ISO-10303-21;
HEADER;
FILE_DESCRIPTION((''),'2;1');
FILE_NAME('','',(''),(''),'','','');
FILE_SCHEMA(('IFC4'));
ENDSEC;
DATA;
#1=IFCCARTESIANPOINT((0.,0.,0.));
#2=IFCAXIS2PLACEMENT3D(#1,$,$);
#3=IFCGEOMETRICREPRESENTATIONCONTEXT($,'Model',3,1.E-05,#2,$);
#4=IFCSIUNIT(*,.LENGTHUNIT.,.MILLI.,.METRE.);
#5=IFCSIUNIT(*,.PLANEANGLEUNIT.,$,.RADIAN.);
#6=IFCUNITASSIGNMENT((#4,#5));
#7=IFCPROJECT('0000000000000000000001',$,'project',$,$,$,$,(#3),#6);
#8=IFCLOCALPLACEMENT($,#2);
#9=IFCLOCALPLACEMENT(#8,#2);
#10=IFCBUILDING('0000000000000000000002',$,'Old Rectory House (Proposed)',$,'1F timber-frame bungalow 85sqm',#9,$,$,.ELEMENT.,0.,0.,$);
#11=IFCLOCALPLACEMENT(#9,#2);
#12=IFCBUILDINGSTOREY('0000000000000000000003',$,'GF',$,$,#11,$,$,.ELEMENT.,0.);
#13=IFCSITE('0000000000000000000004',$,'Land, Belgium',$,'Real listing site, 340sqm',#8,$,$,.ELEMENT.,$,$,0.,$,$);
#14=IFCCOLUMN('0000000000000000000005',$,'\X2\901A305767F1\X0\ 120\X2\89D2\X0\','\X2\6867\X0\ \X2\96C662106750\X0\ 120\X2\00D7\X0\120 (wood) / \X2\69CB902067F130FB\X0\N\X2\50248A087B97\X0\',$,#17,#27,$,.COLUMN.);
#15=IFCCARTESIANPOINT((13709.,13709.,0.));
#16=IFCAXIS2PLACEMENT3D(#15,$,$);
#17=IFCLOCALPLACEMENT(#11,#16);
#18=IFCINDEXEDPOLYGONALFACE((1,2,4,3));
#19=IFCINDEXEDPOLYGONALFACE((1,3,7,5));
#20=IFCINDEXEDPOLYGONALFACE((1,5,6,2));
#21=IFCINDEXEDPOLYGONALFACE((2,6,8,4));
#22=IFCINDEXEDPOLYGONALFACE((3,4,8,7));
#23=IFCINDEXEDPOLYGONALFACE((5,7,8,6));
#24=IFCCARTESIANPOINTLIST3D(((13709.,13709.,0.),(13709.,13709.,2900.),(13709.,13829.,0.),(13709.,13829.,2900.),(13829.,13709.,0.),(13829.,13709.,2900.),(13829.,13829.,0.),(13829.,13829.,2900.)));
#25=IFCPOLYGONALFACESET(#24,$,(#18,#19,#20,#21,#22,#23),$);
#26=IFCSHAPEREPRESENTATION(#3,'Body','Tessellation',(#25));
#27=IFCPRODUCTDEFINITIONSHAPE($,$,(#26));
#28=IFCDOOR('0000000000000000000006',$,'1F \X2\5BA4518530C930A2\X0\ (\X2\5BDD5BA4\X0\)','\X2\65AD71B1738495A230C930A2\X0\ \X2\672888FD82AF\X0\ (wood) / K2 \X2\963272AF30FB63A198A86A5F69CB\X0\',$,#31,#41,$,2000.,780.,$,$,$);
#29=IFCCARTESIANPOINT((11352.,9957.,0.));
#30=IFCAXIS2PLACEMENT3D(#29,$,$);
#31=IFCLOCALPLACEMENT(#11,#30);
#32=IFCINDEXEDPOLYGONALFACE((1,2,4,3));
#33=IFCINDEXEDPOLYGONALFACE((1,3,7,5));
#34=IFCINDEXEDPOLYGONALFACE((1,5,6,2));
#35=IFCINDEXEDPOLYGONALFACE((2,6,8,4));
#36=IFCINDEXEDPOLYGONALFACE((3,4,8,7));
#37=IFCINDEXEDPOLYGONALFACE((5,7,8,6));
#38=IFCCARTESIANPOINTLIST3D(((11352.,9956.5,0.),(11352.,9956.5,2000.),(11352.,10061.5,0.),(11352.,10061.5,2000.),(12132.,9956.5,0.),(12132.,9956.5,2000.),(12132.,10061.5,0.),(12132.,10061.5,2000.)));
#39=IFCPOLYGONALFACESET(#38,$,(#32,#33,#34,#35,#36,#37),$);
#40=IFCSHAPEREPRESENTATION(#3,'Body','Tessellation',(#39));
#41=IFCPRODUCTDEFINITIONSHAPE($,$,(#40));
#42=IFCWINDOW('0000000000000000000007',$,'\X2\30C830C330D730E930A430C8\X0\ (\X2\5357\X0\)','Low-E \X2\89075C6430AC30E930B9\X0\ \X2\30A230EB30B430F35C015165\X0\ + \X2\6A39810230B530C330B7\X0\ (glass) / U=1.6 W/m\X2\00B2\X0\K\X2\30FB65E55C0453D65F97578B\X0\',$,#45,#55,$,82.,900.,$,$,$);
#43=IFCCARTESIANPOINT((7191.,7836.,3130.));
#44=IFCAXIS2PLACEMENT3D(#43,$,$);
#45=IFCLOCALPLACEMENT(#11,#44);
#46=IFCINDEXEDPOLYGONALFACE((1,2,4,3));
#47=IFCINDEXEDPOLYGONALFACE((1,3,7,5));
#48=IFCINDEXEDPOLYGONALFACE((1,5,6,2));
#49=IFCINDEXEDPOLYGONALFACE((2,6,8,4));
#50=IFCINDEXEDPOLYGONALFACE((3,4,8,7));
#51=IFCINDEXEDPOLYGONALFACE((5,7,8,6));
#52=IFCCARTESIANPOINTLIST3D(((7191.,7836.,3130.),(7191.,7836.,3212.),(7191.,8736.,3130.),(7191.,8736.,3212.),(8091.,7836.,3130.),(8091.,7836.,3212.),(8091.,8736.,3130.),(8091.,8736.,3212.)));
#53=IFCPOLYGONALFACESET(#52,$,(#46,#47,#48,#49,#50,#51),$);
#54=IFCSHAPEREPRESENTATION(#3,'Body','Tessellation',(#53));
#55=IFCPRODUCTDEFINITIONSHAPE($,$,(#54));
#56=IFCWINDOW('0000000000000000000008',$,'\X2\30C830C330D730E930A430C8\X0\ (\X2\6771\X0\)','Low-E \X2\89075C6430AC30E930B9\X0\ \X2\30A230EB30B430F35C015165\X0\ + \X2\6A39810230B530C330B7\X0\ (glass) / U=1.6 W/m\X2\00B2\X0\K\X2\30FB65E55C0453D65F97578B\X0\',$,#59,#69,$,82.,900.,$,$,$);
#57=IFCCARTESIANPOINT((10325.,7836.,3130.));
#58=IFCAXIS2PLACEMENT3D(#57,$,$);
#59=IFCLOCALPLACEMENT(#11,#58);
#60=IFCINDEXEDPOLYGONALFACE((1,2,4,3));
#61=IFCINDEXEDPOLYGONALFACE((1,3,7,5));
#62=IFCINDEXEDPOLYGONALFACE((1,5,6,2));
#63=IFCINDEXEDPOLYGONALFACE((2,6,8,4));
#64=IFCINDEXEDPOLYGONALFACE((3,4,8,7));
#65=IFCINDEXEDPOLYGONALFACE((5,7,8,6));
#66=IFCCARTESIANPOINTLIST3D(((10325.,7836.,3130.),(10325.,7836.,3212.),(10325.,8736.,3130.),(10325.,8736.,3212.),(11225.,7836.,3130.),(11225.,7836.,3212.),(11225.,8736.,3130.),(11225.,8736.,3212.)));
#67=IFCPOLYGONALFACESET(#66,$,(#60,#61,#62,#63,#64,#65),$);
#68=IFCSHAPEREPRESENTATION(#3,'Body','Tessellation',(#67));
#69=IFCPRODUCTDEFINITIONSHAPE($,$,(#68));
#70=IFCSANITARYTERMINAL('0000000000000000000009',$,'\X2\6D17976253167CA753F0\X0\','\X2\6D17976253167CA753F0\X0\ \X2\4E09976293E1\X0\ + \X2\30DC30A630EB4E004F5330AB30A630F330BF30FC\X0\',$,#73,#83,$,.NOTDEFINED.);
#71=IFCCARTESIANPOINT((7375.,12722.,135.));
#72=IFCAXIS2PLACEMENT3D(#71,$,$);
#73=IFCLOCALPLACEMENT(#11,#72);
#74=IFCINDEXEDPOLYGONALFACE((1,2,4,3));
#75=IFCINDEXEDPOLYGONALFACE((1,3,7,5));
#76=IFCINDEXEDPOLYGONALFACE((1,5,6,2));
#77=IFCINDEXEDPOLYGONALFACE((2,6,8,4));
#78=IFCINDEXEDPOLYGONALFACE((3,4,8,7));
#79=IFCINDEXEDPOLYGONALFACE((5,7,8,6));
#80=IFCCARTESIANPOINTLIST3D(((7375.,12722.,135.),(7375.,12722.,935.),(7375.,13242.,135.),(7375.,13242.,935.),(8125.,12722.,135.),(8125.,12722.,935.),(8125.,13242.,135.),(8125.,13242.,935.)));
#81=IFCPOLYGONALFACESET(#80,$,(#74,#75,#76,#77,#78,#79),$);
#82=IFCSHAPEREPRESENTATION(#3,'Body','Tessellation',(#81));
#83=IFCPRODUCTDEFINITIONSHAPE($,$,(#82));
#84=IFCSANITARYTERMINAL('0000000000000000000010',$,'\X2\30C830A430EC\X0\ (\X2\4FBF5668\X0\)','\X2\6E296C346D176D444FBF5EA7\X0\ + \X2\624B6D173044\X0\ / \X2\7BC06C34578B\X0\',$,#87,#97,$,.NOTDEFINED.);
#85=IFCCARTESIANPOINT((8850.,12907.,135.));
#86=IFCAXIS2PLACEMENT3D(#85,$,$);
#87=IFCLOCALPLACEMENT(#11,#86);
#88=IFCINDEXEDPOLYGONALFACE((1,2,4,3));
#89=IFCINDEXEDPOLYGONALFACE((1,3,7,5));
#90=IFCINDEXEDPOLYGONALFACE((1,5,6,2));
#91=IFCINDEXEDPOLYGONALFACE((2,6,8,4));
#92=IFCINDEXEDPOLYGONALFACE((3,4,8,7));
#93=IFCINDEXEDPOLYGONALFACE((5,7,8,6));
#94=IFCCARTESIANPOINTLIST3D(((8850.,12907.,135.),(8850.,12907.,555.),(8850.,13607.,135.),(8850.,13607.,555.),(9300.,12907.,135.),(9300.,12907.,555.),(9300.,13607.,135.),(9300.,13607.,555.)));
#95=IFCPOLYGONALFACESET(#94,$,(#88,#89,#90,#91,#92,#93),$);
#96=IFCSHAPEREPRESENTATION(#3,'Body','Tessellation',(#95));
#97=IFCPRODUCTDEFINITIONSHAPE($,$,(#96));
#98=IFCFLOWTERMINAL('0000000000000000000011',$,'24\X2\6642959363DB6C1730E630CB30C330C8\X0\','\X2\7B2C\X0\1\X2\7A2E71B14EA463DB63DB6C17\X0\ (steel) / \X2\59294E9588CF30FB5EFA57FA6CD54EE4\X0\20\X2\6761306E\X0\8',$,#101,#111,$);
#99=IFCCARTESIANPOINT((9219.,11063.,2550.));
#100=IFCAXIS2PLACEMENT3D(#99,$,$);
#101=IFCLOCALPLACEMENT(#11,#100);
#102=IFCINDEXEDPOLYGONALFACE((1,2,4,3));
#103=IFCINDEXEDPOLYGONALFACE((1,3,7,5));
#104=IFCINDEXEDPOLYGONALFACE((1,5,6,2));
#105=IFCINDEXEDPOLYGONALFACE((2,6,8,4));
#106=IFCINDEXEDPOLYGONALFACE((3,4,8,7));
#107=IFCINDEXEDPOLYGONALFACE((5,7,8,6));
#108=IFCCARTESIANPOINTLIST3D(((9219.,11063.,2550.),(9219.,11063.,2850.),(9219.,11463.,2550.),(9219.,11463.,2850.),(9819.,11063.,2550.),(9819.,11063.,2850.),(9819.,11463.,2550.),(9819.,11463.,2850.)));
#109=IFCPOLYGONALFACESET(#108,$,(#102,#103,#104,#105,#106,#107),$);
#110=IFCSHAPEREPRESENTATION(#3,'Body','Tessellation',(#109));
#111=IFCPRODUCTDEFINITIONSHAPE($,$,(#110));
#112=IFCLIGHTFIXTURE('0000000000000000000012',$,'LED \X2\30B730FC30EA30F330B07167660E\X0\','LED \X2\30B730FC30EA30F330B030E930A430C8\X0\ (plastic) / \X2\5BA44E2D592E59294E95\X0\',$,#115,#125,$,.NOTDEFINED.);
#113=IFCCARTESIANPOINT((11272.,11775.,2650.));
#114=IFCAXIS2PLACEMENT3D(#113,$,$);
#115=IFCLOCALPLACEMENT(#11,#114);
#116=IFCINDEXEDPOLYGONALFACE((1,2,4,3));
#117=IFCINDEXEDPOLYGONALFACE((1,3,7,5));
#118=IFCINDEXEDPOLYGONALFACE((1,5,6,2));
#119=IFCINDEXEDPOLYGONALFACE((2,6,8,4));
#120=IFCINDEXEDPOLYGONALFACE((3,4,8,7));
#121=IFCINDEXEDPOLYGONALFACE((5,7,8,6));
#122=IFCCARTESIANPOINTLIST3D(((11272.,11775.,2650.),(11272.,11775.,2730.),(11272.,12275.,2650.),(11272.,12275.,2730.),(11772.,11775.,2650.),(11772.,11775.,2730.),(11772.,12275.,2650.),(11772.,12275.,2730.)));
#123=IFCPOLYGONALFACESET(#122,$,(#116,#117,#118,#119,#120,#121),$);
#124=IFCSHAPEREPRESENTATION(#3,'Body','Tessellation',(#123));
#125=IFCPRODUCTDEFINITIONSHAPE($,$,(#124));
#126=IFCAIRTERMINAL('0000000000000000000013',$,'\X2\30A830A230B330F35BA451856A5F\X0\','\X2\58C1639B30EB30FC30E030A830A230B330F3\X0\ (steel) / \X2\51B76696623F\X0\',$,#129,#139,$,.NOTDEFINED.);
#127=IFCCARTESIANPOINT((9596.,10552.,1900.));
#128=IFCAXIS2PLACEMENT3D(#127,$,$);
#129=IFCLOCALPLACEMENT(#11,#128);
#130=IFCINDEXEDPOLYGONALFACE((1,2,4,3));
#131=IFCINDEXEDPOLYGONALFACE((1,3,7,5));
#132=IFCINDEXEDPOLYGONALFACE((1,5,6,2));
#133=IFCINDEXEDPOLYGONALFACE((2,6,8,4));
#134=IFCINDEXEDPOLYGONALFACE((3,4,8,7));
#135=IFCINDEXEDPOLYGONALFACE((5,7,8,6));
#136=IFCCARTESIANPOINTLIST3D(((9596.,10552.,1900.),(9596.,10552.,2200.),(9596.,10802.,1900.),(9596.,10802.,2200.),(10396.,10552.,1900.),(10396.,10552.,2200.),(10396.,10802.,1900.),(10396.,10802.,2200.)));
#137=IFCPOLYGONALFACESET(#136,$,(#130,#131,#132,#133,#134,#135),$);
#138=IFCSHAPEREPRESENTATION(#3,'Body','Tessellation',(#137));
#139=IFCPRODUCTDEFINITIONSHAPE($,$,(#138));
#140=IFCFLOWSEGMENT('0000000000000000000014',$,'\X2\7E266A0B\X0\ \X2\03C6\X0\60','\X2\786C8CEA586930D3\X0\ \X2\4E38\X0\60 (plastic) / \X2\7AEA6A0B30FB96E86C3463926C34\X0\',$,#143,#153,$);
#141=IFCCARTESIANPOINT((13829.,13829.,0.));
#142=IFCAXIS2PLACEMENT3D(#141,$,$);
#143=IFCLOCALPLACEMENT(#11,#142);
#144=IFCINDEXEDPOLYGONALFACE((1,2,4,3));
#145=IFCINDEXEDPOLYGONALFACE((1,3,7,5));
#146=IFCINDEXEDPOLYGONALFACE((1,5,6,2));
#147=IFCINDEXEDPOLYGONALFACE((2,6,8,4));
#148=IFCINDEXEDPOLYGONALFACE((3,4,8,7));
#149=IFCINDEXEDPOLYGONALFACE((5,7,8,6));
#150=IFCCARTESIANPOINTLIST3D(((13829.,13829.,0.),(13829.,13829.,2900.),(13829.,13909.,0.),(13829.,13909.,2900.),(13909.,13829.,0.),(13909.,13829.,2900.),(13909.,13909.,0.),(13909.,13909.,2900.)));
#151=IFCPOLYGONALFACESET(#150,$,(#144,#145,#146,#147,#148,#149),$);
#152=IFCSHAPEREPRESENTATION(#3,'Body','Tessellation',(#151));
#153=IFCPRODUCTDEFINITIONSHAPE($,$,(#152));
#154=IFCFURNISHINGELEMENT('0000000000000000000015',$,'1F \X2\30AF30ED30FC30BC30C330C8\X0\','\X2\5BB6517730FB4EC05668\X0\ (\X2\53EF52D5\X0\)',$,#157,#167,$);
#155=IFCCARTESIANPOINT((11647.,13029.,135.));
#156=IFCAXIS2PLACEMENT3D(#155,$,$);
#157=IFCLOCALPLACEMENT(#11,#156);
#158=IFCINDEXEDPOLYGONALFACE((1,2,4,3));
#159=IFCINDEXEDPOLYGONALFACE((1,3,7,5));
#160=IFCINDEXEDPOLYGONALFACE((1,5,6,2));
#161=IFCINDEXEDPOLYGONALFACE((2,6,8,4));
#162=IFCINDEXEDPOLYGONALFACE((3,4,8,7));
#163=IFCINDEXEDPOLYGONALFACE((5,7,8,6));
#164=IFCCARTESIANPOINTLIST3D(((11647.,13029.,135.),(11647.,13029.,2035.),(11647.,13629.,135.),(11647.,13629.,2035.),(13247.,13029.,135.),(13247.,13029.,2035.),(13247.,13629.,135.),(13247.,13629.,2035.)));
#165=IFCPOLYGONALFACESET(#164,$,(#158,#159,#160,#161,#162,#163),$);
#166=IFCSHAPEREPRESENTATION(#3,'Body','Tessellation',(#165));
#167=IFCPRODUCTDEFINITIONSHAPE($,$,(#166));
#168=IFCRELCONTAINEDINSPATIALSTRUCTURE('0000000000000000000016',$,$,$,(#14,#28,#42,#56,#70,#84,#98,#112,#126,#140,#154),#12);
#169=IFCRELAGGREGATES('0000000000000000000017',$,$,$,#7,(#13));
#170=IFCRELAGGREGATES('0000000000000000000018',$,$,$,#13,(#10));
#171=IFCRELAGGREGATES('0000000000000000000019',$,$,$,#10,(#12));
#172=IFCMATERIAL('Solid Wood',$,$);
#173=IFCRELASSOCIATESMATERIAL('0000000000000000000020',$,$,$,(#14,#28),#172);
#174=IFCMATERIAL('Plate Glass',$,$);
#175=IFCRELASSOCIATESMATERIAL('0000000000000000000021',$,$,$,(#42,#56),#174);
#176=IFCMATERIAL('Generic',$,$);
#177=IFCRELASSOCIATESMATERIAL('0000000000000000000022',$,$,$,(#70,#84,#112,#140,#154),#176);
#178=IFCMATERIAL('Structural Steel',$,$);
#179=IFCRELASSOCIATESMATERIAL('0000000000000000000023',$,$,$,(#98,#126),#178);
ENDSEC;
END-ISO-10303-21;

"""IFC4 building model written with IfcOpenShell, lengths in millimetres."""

from ifc_helpers import new_model, si_unit, frame, frame_2d, origin, place, context, project, spatial, rectangle, extrude, material, element, save


model = new_model("IFC4")

# Units and contexts
model_context = context("Model", 3, precision=1e-05, world=origin())
ifc_project = project(units=[si_unit("LENGTHUNIT", "METRE", prefix="MILLI"), si_unit("PLANEANGLEUNIT", "RADIAN")], contexts=[model_context])

# Site, building, storey
site_placement = place(None, origin())
site = spatial("IfcSite", under=ifc_project, at=site_placement, Name="Land, Belgium", ObjectType="Real listing site, 340sqm", CompositionType="ELEMENT", RefElevation=0.0)
building_placement = place(site_placement, origin())
building = spatial("IfcBuilding", under=site, at=building_placement, Name="Old Rectory House (Proposed)", ObjectType="1F timber-frame bungalow 85sqm", CompositionType="ELEMENT", ElevationOfRefHeight=0.0, ElevationOfTerrain=0.0)
storey_placement = place(building_placement, origin())
storey = spatial("IfcBuildingStorey", under=building, at=storey_placement, Name="GF", CompositionType="ELEMENT", Elevation=0.0)

# Column
ifc_material_1 = material(Name="Solid Wood")
column_1_placement = place(storey_placement, frame((13709.0, 13709.0, 0.0)))
element("IfcColumn", 1, at=column_1_placement, inside=storey, material=ifc_material_1, Name="通し柱 120角", Description="桧 集成材 120×120 (wood) / 構造柱・N値計算", PredefinedType="COLUMN", context=model_context, shape_type="SweptSolid", body=[
    extrude(rectangle(XDim=120.0, YDim=120.0, at=frame_2d((60.0, 60.0))), frame((13709.0, 13709.0, 0.0)), (0.0, 0.0, 1.0), 2900.0),
])

# Door
door_placement = place(storey_placement, frame((11352.0, 9957.0, 0.0)))
element("IfcDoor", 2, at=door_placement, inside=storey, material=ifc_material_1, Name="1F 室内ドア (寝室)", Description="断熱玄関ドア 木製芯 (wood) / K2 防犯・採風機構", OverallHeight=2000.0, OverallWidth=780.0, context=model_context, shape_type="SweptSolid", body=[
    extrude(rectangle(XDim=780.0, YDim=105.0, at=frame_2d((390.0, 52.0))), frame((11352.0, 9957.0, 0.0)), (0.0, 0.0, 1.0), 2000.0),
])

# Windows
ifc_material_2 = material(Name="Plate Glass")
window_1_placement = place(storey_placement, frame((7191.0, 7836.0, 3130.0)))
element("IfcWindow", 3, at=window_1_placement, inside=storey, material=ifc_material_2, Name="トップライト (南)", Description="Low-E 複層ガラス アルゴン封入 + 樹脂サッシ (glass) / U=1.6 W/m²K・日射取得型", OverallHeight=82.0, OverallWidth=900.0, context=model_context, shape_type="SweptSolid", body=[
    extrude(rectangle(XDim=900.0, YDim=900.0, at=frame_2d((450.0, 450.0))), frame((7191.0, 7836.0, 3130.0)), (0.0, 0.0, 1.0), 82.0),
])
window_2_placement = place(storey_placement, frame((10325.0, 7836.0, 3130.0)))
element("IfcWindow", 4, at=window_2_placement, inside=storey, material=ifc_material_2, Name="トップライト (東)", Description="Low-E 複層ガラス アルゴン封入 + 樹脂サッシ (glass) / U=1.6 W/m²K・日射取得型", OverallHeight=82.0, OverallWidth=900.0, context=model_context, shape_type="SweptSolid", body=[
    extrude(rectangle(XDim=900.0, YDim=900.0, at=frame_2d((450.0, 450.0))), frame((10325.0, 7836.0, 3130.0)), (0.0, 0.0, 1.0), 82.0),
])

# Sanitary terminals
ifc_material_3 = material(Name="Generic")
sanitary_terminal_1_placement = place(storey_placement, frame((7375.0, 12722.0, 135.0)))
element("IfcSanitaryTerminal", 5, at=sanitary_terminal_1_placement, inside=storey, material=ifc_material_3, Name="洗面化粧台", Description="洗面化粧台 三面鏡 + ボウル一体カウンター", PredefinedType="NOTDEFINED", context=model_context, shape_type="SweptSolid", body=[
    extrude(rectangle(XDim=750.0, YDim=520.0, at=frame_2d((375.0, 260.0))), frame((7375.0, 12722.0, 135.0)), (0.0, 0.0, 1.0), 800.0),
])
sanitary_terminal_2_placement = place(storey_placement, frame((8850.0, 12907.0, 135.0)))
element("IfcSanitaryTerminal", 6, at=sanitary_terminal_2_placement, inside=storey, material=ifc_material_3, Name="トイレ (便器)", Description="温水洗浄便座 + 手洗い / 節水型", PredefinedType="NOTDEFINED", context=model_context, shape_type="SweptSolid", body=[
    extrude(rectangle(XDim=450.0, YDim=700.0, at=frame_2d((225.0, 350.0))), frame((8850.0, 12907.0, 135.0)), (0.0, 0.0, 1.0), 420.0),
])

# Flow terminal
ifc_material_4 = material(Name="Structural Steel")
flow_terminal_placement = place(storey_placement, frame((9219.0, 11063.0, 2550.0)))
element("IfcFlowTerminal", 7, at=flow_terminal_placement, inside=storey, material=ifc_material_4, Name="24時間換気ユニット", Description="第1種熱交換換気 (steel) / 天井裏・建基法令20条の8", context=model_context, shape_type="SweptSolid", body=[
    extrude(rectangle(XDim=600.0, YDim=400.0, at=frame_2d((300.0, 200.0))), frame((9219.0, 11063.0, 2550.0)), (0.0, 0.0, 1.0), 300.0),
])

# Light fixture
light_fixture_placement = place(storey_placement, frame((11272.0, 11775.0, 2650.0)))
element("IfcLightFixture", 8, at=light_fixture_placement, inside=storey, material=ifc_material_3, Name="LED シーリング照明", Description="LED シーリングライト (plastic) / 室中央天井", PredefinedType="NOTDEFINED", context=model_context, shape_type="SweptSolid", body=[
    extrude(rectangle(XDim=500.0, YDim=500.0, at=frame_2d((250.0, 250.0))), frame((11272.0, 11775.0, 2650.0)), (0.0, 0.0, 1.0), 80.0),
])

# Air terminal
air_terminal_placement = place(storey_placement, frame((9596.0, 10552.0, 1900.0)))
element("IfcAirTerminal", 9, at=air_terminal_placement, inside=storey, material=ifc_material_4, Name="エアコン室内機", Description="壁掛ルームエアコン (steel) / 冷暖房", PredefinedType="NOTDEFINED", context=model_context, shape_type="SweptSolid", body=[
    extrude(rectangle(XDim=800.0, YDim=250.0, at=frame_2d((400.0, 125.0))), frame((9596.0, 10552.0, 1900.0)), (0.0, 0.0, 1.0), 300.0),
])

# Flow segment
flow_segment_placement = place(storey_placement, frame((13829.0, 13829.0, 0.0)))
element("IfcFlowSegment", 10, at=flow_segment_placement, inside=storey, material=ifc_material_3, Name="縦樋 φ60", Description="硬質塩ビ 丸60 (plastic) / 竪樋・雨水排水", context=model_context, shape_type="SweptSolid", body=[
    extrude(rectangle(XDim=80.0, YDim=80.0, at=frame_2d((40.0, 40.0))), frame((13829.0, 13829.0, 0.0)), (0.0, 0.0, 1.0), 2900.0),
])

# Furnishing element
furnishing_placement = place(storey_placement, frame((11647.0, 13029.0, 135.0)))
element("IfcFurnishingElement", 11, at=furnishing_placement, inside=storey, material=ifc_material_3, Name="1F クローゼット", Description="家具・什器 (可動)", context=model_context, shape_type="SweptSolid", body=[
    extrude(rectangle(XDim=1600.0, YDim=600.0, at=frame_2d((800.0, 300.0))), frame((11647.0, 13029.0, 135.0)), (0.0, 0.0, 1.0), 1900.0),
])

save(model, "model.ifc")
